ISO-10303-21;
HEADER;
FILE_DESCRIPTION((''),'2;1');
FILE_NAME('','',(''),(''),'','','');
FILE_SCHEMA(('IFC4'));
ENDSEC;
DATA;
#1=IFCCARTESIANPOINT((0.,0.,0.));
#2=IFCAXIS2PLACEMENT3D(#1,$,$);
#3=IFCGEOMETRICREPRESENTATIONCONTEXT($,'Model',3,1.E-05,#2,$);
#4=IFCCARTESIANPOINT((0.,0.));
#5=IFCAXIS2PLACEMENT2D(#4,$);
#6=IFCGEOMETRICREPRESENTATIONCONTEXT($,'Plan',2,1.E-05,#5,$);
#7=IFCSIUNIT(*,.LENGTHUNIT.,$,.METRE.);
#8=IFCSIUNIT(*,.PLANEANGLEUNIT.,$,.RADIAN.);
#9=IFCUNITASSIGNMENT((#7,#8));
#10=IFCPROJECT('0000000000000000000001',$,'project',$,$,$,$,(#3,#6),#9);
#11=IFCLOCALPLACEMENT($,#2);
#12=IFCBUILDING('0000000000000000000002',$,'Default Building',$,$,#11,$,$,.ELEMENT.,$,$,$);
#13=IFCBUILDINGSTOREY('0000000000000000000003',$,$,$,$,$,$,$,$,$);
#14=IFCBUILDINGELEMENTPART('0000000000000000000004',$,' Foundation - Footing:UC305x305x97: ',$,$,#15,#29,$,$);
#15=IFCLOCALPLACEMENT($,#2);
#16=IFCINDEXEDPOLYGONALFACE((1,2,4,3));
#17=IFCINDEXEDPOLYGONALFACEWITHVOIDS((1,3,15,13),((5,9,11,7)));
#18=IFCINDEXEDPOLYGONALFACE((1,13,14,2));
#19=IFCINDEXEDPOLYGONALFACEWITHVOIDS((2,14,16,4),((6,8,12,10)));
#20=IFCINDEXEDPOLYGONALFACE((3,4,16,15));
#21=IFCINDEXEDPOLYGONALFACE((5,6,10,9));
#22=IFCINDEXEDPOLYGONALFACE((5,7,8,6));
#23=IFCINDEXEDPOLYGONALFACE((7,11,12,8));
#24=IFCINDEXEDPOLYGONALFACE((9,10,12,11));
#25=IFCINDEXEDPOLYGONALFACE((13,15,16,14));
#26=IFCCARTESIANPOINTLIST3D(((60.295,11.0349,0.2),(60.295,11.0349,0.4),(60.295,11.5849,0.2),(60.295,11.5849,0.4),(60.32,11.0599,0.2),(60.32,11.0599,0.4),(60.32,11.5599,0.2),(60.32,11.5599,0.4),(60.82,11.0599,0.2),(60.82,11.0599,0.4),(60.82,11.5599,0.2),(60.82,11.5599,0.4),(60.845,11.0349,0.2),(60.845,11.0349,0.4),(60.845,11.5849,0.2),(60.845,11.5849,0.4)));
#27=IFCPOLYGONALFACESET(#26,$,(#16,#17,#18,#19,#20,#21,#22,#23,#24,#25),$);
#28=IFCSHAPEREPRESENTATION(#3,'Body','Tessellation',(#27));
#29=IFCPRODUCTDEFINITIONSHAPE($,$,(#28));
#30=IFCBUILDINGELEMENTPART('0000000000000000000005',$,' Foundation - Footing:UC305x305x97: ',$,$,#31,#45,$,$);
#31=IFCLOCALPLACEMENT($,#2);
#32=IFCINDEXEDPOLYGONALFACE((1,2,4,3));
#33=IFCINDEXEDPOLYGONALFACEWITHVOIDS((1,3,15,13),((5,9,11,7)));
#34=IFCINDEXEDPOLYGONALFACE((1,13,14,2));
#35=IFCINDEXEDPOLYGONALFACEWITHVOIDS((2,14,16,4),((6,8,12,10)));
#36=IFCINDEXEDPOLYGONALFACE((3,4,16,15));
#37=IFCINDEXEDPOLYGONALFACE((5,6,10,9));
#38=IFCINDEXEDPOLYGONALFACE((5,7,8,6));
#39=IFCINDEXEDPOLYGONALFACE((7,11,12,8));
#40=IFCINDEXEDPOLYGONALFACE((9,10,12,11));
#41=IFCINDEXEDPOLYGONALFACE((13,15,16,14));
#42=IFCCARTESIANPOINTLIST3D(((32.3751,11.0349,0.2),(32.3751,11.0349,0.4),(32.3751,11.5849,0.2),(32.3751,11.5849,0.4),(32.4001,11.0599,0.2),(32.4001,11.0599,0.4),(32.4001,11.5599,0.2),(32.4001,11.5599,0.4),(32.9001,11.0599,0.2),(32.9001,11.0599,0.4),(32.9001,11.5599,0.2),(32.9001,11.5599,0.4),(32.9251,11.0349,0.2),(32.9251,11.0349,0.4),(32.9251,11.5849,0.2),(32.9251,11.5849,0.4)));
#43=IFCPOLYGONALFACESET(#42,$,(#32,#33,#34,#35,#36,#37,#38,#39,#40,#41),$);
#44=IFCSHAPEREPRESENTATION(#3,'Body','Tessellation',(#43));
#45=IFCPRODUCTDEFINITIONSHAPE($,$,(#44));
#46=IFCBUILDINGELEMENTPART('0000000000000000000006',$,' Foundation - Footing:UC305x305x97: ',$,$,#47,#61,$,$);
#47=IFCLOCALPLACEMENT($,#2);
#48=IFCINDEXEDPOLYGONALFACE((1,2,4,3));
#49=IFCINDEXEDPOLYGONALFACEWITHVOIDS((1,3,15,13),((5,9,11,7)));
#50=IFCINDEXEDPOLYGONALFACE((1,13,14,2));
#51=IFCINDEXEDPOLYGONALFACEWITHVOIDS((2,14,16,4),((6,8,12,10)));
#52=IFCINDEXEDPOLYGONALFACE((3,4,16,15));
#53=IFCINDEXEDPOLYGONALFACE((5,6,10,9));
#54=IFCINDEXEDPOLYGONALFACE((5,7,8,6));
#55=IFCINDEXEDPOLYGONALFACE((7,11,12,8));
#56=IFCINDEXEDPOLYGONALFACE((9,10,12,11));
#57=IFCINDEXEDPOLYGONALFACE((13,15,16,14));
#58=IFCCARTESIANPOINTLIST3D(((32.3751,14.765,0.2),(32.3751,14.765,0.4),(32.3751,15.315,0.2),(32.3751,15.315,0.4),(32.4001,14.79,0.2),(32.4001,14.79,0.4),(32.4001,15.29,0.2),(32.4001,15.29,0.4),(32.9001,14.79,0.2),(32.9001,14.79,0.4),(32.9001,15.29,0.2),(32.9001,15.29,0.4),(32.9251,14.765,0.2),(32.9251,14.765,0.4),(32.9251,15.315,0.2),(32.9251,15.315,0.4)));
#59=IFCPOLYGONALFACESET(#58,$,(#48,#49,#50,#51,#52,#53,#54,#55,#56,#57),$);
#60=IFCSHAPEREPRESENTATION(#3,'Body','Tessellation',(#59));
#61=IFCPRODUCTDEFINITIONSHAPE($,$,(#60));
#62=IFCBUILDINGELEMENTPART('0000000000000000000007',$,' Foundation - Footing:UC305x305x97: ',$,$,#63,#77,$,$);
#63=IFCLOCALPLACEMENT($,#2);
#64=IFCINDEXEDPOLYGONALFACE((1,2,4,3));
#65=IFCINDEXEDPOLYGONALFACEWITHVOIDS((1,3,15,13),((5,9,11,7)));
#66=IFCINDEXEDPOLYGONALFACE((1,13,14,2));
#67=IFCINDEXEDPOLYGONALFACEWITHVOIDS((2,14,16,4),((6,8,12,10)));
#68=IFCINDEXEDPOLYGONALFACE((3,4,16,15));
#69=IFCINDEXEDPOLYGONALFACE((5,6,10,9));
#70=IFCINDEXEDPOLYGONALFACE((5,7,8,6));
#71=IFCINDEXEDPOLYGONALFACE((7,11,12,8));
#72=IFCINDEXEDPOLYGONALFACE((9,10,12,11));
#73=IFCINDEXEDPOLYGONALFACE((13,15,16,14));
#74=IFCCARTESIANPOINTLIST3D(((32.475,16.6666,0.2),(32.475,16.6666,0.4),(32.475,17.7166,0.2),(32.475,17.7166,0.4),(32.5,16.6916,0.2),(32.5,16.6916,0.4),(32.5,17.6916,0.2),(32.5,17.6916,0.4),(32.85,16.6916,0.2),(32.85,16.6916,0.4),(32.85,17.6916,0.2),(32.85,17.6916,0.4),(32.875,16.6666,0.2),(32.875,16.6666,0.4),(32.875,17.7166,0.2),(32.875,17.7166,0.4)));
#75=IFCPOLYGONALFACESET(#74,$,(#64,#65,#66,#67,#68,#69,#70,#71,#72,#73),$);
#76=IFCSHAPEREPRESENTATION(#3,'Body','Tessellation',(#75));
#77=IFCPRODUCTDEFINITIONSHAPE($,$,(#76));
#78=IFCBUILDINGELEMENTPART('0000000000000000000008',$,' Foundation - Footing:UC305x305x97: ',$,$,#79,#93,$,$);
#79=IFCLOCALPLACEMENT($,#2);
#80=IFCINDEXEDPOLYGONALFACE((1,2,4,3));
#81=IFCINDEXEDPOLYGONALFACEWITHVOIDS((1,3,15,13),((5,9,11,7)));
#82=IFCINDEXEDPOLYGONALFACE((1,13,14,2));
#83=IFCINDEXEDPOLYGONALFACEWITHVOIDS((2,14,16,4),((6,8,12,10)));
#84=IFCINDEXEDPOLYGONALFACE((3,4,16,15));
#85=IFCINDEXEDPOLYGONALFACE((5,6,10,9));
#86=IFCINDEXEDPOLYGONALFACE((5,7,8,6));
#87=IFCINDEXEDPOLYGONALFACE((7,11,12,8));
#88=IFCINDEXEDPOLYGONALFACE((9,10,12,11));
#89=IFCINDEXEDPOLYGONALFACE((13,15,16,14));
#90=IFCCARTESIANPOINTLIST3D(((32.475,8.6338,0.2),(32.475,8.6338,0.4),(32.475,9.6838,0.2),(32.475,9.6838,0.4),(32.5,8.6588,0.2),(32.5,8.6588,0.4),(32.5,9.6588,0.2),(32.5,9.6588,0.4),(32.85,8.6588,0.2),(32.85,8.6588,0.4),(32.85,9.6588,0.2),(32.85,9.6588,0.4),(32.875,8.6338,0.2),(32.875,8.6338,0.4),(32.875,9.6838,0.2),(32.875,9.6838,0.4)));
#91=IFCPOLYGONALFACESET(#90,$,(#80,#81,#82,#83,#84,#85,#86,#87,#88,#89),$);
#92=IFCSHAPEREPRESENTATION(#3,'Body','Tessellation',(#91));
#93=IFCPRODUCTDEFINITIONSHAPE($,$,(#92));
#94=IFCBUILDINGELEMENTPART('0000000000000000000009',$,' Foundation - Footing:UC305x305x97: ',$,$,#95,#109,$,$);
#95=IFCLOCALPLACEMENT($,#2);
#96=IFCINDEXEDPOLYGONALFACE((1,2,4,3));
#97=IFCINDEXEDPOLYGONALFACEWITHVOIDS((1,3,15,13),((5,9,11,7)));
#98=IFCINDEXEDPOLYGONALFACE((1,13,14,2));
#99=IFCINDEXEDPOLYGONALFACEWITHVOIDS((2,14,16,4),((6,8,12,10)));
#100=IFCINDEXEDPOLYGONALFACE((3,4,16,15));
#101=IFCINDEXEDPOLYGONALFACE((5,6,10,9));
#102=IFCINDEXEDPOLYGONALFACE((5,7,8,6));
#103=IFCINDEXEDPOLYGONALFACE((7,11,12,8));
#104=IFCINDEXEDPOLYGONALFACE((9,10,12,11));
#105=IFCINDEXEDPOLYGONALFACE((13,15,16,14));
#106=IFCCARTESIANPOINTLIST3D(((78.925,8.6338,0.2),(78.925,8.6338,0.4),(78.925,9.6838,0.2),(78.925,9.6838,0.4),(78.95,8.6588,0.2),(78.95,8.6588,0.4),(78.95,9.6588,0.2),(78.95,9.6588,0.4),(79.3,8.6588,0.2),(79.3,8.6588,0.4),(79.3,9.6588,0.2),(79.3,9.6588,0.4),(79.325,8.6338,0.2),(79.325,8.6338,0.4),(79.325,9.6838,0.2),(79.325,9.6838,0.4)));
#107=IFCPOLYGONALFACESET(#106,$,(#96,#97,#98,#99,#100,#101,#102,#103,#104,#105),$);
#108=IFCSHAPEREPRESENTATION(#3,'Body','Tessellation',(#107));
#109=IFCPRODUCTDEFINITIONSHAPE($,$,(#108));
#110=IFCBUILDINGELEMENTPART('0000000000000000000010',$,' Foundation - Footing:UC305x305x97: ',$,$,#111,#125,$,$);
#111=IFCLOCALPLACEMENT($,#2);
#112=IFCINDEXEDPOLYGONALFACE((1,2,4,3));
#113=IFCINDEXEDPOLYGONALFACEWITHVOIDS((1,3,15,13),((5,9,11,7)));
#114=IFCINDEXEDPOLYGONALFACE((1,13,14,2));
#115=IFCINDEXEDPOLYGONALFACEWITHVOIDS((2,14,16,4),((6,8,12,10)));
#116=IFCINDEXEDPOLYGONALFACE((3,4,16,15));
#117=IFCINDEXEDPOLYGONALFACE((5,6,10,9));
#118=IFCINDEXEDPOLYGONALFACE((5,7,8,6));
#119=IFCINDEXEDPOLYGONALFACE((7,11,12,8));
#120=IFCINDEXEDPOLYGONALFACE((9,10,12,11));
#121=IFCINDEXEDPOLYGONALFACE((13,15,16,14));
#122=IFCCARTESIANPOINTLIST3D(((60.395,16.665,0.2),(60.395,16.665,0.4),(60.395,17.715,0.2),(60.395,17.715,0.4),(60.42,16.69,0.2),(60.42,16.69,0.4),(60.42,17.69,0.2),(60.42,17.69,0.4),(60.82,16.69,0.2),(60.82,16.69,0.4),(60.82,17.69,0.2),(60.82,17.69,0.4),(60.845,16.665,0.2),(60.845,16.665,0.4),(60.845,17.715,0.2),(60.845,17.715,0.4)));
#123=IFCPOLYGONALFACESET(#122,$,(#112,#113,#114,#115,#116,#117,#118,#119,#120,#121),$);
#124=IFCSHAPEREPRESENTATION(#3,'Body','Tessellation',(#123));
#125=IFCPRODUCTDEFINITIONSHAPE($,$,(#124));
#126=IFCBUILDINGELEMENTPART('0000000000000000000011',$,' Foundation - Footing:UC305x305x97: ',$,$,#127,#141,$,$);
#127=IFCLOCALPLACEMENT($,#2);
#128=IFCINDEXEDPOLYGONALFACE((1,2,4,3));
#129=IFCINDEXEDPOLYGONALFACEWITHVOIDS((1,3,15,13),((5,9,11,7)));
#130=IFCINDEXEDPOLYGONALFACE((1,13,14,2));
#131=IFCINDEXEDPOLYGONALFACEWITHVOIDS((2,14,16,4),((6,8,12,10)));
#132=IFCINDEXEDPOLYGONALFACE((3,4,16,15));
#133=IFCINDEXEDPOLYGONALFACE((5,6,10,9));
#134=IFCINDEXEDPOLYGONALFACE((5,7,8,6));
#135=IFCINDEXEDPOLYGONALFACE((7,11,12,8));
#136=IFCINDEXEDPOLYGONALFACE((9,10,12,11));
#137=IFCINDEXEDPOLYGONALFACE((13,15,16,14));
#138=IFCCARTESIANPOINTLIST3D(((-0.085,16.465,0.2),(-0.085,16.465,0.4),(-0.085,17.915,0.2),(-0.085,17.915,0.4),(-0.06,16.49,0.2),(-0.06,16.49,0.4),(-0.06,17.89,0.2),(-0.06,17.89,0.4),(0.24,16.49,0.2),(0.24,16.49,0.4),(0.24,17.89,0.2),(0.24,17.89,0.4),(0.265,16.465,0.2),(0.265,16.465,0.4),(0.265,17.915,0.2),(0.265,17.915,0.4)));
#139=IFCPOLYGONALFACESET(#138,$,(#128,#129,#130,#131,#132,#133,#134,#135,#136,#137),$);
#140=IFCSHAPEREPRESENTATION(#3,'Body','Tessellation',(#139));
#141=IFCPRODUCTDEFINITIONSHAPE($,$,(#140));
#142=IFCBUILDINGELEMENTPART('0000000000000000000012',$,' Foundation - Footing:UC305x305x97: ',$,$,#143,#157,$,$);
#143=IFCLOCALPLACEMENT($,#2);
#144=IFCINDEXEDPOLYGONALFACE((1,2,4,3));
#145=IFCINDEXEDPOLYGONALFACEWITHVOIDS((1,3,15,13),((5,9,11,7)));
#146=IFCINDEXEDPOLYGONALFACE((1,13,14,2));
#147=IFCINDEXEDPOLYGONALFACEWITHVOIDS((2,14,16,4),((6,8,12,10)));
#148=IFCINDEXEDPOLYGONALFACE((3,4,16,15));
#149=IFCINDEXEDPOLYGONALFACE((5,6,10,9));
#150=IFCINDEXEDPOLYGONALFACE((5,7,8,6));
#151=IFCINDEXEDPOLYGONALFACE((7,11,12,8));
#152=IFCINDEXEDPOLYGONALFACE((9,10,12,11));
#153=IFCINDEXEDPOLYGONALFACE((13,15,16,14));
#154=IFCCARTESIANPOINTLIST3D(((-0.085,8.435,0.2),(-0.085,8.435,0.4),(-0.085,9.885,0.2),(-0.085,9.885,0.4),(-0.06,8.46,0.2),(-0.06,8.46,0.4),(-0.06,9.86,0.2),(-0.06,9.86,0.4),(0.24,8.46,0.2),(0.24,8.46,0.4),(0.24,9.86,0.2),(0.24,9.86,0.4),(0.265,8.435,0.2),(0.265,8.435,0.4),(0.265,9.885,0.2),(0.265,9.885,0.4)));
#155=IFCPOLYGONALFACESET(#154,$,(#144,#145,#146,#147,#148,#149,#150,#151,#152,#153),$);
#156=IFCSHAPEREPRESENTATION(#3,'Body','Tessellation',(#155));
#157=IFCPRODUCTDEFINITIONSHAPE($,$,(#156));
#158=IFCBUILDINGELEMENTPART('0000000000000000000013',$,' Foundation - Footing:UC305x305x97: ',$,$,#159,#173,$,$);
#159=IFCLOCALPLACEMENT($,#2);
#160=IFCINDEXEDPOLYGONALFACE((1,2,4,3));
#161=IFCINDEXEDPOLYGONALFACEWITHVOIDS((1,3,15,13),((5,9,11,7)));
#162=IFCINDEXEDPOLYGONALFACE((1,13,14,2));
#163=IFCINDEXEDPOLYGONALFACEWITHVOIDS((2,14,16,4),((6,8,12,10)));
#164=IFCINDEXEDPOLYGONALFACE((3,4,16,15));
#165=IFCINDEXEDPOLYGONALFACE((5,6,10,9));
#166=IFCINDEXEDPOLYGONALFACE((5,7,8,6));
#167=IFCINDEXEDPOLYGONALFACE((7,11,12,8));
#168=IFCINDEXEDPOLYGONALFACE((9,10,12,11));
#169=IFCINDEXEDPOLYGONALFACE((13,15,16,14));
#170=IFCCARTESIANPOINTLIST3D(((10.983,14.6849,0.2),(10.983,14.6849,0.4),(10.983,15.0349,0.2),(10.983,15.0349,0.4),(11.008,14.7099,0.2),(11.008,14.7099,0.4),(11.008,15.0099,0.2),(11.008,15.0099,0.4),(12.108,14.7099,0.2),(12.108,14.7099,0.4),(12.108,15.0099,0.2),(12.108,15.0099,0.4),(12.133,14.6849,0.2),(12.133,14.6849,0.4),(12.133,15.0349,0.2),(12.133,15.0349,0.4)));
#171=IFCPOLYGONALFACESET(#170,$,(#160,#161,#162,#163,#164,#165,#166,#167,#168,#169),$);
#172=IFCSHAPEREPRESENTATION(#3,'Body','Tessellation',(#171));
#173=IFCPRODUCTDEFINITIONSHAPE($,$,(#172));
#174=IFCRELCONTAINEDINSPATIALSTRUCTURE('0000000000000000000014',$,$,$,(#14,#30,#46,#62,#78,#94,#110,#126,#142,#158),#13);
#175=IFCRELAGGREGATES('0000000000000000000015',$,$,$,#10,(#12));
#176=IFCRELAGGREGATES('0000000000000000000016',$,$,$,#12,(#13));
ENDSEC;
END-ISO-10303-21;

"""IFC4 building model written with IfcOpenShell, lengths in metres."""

from ifc_helpers import new_model, si_unit, origin, origin_2d, place, context, project, spatial, polyline, outline, extrude, element, save


model = new_model("IFC4")

# Units and contexts
model_context = context("Model", 3, precision=1e-05, world=origin())
plan_context = context("Plan", 2, precision=1e-05, world=origin_2d())
ifc_project = project(units=[si_unit("LENGTHUNIT", "METRE"), si_unit("PLANEANGLEUNIT", "RADIAN")], contexts=[model_context, plan_context])

# Building, storey
building_placement = place(None, origin())
building = spatial("IfcBuilding", under=ifc_project, at=building_placement, Name="Default Building", CompositionType="ELEMENT")
storey = spatial("IfcBuildingStorey", under=building)

# Building element parts, openings
building_element_part_1 = element("IfcBuildingElementPart", 1, inside=storey, Name=" Foundation - Footing:UC305x305x97: ", context=model_context, shape_type="SweptSolid", body=[
    extrude(outline(polyline([(60.845, 11.0349, 0.2), (60.295, 11.0349, 0.2), (60.295, 11.5849, 0.2), (60.845, 11.5849, 0.2), (60.845, 11.0349, 0.2)])), None, (0.0, 0.0, 1.0), 0.2),
])
element("IfcOpeningElement", 2, inside=storey, cuts=building_element_part_1, context=model_context, shape_type="SweptSolid", body=[
    extrude(outline(polyline([(60.82, 11.0599, 0.2), (60.32, 11.0599, 0.2), (60.32, 11.5599, 0.2), (60.82, 11.5599, 0.2), (60.82, 11.0599, 0.2)])), None, (0.0, 0.0, 1.0), 0.2),
])
building_element_part_2 = element("IfcBuildingElementPart", 3, inside=storey, Name=" Foundation - Footing:UC305x305x97: ", context=model_context, shape_type="SweptSolid", body=[
    extrude(outline(polyline([(32.9251, 11.0349, 0.2), (32.3751, 11.0349, 0.2), (32.3751, 11.5849, 0.2), (32.9251, 11.5849, 0.2), (32.9251, 11.0349, 0.2)])), None, (0.0, 0.0, 1.0), 0.2),
])
element("IfcOpeningElement", 4, inside=storey, cuts=building_element_part_2, context=model_context, shape_type="SweptSolid", body=[
    extrude(outline(polyline([(32.9001, 11.0599, 0.2), (32.4001, 11.0599, 0.2), (32.4001, 11.5599, 0.2), (32.9001, 11.5599, 0.2), (32.9001, 11.0599, 0.2)])), None, (0.0, 0.0, 1.0), 0.2),
])
building_element_part_3 = element("IfcBuildingElementPart", 5, inside=storey, Name=" Foundation - Footing:UC305x305x97: ", context=model_context, shape_type="SweptSolid", body=[
    extrude(outline(polyline([(32.9251, 15.315, 0.2), (32.3751, 15.315, 0.2), (32.3751, 14.765, 0.2), (32.9251, 14.765, 0.2), (32.9251, 15.315, 0.2)])), None, (0.0, 0.0, 1.0), 0.2),
])
element("IfcOpeningElement", 6, inside=storey, cuts=building_element_part_3, context=model_context, shape_type="SweptSolid", body=[
    extrude(outline(polyline([(32.9001, 15.29, 0.2), (32.4001, 15.29, 0.2), (32.4001, 14.79, 0.2), (32.9001, 14.79, 0.2), (32.9001, 15.29, 0.2)])), None, (0.0, 0.0, 1.0), 0.2),
])
building_element_part_4 = element("IfcBuildingElementPart", 7, inside=storey, Name=" Foundation - Footing:UC305x305x97: ", context=model_context, shape_type="SweptSolid", body=[
    extrude(outline(polyline([(32.475, 17.7166, 0.2), (32.875, 17.7166, 0.2), (32.875, 16.6666, 0.2), (32.475, 16.6666, 0.2), (32.475, 17.7166, 0.2)])), None, (0.0, 0.0, 1.0), 0.2),
])
element("IfcOpeningElement", 8, inside=storey, cuts=building_element_part_4, context=model_context, shape_type="SweptSolid", body=[
    extrude(outline(polyline([(32.5, 17.6916, 0.2), (32.85, 17.6916, 0.2), (32.85, 16.6916, 0.2), (32.5, 16.6916, 0.2), (32.5, 17.6916, 0.2)])), None, (0.0, 0.0, 1.0), 0.2),
])
building_element_part_5 = element("IfcBuildingElementPart", 9, inside=storey, Name=" Foundation - Footing:UC305x305x97: ", context=model_context, shape_type="SweptSolid", body=[
    extrude(outline(polyline([(32.475, 8.6338, 0.2), (32.875, 8.6338, 0.2), (32.875, 9.6838, 0.2), (32.475, 9.6838, 0.2), (32.475, 8.6338, 0.2)])), None, (0.0, 0.0, 1.0), 0.2),
])
element("IfcOpeningElement", 10, inside=storey, cuts=building_element_part_5, context=model_context, shape_type="SweptSolid", body=[
    extrude(outline(polyline([(32.5, 8.6588, 0.2), (32.85, 8.6588, 0.2), (32.85, 9.6588, 0.2), (32.5, 9.6588, 0.2), (32.5, 8.6588, 0.2)])), None, (0.0, 0.0, 1.0), 0.2),
])
building_element_part_6 = element("IfcBuildingElementPart", 11, inside=storey, Name=" Foundation - Footing:UC305x305x97: ", context=model_context, shape_type="SweptSolid", body=[
    extrude(outline(polyline([(79.325, 8.6338, 0.2), (78.925, 8.6338, 0.2), (78.925, 9.6838, 0.2), (79.325, 9.6838, 0.2), (79.325, 8.6338, 0.2)])), None, (0.0, 0.0, 1.0), 0.2),
])
element("IfcOpeningElement", 12, inside=storey, cuts=building_element_part_6, context=model_context, shape_type="SweptSolid", body=[
    extrude(outline(polyline([(79.3, 8.6588, 0.2), (78.95, 8.6588, 0.2), (78.95, 9.6588, 0.2), (79.3, 9.6588, 0.2), (79.3, 8.6588, 0.2)])), None, (0.0, 0.0, 1.0), 0.2),
])
building_element_part_7 = element("IfcBuildingElementPart", 13, inside=storey, Name=" Foundation - Footing:UC305x305x97: ", context=model_context, shape_type="SweptSolid", body=[
    extrude(outline(polyline([(60.395, 17.715, 0.2), (60.845, 17.715, 0.2), (60.845, 16.665, 0.2), (60.395, 16.665, 0.2), (60.395, 17.715, 0.2)])), None, (0.0, 0.0, 1.0), 0.2),
])
element("IfcOpeningElement", 14, inside=storey, cuts=building_element_part_7, context=model_context, shape_type="SweptSolid", body=[
    extrude(outline(polyline([(60.42, 17.69, 0.2), (60.82, 17.69, 0.2), (60.82, 16.69, 0.2), (60.42, 16.69, 0.2), (60.42, 17.69, 0.2)])), None, (0.0, 0.0, 1.0), 0.2),
])
building_element_part_8 = element("IfcBuildingElementPart", 15, inside=storey, Name=" Foundation - Footing:UC305x305x97: ", context=model_context, shape_type="SweptSolid", body=[
    extrude(outline(polyline([(-0.085, 17.915, 0.2), (0.265, 17.915, 0.2), (0.265, 16.465, 0.2), (-0.085, 16.465, 0.2), (-0.085, 17.915, 0.2)])), None, (0.0, 0.0, 1.0), 0.2),
])
element("IfcOpeningElement", 16, inside=storey, cuts=building_element_part_8, context=model_context, shape_type="SweptSolid", body=[
    extrude(outline(polyline([(-0.06, 17.89, 0.2), (0.24, 17.89, 0.2), (0.24, 16.49, 0.2), (-0.06, 16.49, 0.2), (-0.06, 17.89, 0.2)])), None, (0.0, 0.0, 1.0), 0.2),
])
building_element_part_9 = element("IfcBuildingElementPart", 17, inside=storey, Name=" Foundation - Footing:UC305x305x97: ", context=model_context, shape_type="SweptSolid", body=[
    extrude(outline(polyline([(-0.085, 8.435, 0.2), (0.265, 8.435, 0.2), (0.265, 9.885, 0.2), (-0.085, 9.885, 0.2), (-0.085, 8.435, 0.2)])), None, (0.0, 0.0, 1.0), 0.2),
])
element("IfcOpeningElement", 18, inside=storey, cuts=building_element_part_9, context=model_context, shape_type="SweptSolid", body=[
    extrude(outline(polyline([(-0.06, 8.46, 0.2), (0.24, 8.46, 0.2), (0.24, 9.86, 0.2), (-0.06, 9.86, 0.2), (-0.06, 8.46, 0.2)])), None, (0.0, 0.0, 1.0), 0.2),
])
building_element_part_10 = element("IfcBuildingElementPart", 19, inside=storey, Name=" Foundation - Footing:UC305x305x97: ", context=model_context, shape_type="SweptSolid", body=[
    extrude(outline(polyline([(10.983, 14.6849, 0.2), (10.983, 15.0349, 0.2), (12.133, 15.0349, 0.2), (12.133, 14.6849, 0.2), (10.983, 14.6849, 0.2)])), None, (0.0, 0.0, 1.0), 0.2),
])
element("IfcOpeningElement", 20, inside=storey, cuts=building_element_part_10, context=model_context, shape_type="SweptSolid", body=[
    extrude(outline(polyline([(11.008, 14.7099, 0.2), (11.008, 15.0099, 0.2), (12.108, 15.0099, 0.2), (12.108, 14.7099, 0.2), (11.008, 14.7099, 0.2)])), None, (0.0, 0.0, 1.0), 0.2),
])

save(model, "model.ifc")
